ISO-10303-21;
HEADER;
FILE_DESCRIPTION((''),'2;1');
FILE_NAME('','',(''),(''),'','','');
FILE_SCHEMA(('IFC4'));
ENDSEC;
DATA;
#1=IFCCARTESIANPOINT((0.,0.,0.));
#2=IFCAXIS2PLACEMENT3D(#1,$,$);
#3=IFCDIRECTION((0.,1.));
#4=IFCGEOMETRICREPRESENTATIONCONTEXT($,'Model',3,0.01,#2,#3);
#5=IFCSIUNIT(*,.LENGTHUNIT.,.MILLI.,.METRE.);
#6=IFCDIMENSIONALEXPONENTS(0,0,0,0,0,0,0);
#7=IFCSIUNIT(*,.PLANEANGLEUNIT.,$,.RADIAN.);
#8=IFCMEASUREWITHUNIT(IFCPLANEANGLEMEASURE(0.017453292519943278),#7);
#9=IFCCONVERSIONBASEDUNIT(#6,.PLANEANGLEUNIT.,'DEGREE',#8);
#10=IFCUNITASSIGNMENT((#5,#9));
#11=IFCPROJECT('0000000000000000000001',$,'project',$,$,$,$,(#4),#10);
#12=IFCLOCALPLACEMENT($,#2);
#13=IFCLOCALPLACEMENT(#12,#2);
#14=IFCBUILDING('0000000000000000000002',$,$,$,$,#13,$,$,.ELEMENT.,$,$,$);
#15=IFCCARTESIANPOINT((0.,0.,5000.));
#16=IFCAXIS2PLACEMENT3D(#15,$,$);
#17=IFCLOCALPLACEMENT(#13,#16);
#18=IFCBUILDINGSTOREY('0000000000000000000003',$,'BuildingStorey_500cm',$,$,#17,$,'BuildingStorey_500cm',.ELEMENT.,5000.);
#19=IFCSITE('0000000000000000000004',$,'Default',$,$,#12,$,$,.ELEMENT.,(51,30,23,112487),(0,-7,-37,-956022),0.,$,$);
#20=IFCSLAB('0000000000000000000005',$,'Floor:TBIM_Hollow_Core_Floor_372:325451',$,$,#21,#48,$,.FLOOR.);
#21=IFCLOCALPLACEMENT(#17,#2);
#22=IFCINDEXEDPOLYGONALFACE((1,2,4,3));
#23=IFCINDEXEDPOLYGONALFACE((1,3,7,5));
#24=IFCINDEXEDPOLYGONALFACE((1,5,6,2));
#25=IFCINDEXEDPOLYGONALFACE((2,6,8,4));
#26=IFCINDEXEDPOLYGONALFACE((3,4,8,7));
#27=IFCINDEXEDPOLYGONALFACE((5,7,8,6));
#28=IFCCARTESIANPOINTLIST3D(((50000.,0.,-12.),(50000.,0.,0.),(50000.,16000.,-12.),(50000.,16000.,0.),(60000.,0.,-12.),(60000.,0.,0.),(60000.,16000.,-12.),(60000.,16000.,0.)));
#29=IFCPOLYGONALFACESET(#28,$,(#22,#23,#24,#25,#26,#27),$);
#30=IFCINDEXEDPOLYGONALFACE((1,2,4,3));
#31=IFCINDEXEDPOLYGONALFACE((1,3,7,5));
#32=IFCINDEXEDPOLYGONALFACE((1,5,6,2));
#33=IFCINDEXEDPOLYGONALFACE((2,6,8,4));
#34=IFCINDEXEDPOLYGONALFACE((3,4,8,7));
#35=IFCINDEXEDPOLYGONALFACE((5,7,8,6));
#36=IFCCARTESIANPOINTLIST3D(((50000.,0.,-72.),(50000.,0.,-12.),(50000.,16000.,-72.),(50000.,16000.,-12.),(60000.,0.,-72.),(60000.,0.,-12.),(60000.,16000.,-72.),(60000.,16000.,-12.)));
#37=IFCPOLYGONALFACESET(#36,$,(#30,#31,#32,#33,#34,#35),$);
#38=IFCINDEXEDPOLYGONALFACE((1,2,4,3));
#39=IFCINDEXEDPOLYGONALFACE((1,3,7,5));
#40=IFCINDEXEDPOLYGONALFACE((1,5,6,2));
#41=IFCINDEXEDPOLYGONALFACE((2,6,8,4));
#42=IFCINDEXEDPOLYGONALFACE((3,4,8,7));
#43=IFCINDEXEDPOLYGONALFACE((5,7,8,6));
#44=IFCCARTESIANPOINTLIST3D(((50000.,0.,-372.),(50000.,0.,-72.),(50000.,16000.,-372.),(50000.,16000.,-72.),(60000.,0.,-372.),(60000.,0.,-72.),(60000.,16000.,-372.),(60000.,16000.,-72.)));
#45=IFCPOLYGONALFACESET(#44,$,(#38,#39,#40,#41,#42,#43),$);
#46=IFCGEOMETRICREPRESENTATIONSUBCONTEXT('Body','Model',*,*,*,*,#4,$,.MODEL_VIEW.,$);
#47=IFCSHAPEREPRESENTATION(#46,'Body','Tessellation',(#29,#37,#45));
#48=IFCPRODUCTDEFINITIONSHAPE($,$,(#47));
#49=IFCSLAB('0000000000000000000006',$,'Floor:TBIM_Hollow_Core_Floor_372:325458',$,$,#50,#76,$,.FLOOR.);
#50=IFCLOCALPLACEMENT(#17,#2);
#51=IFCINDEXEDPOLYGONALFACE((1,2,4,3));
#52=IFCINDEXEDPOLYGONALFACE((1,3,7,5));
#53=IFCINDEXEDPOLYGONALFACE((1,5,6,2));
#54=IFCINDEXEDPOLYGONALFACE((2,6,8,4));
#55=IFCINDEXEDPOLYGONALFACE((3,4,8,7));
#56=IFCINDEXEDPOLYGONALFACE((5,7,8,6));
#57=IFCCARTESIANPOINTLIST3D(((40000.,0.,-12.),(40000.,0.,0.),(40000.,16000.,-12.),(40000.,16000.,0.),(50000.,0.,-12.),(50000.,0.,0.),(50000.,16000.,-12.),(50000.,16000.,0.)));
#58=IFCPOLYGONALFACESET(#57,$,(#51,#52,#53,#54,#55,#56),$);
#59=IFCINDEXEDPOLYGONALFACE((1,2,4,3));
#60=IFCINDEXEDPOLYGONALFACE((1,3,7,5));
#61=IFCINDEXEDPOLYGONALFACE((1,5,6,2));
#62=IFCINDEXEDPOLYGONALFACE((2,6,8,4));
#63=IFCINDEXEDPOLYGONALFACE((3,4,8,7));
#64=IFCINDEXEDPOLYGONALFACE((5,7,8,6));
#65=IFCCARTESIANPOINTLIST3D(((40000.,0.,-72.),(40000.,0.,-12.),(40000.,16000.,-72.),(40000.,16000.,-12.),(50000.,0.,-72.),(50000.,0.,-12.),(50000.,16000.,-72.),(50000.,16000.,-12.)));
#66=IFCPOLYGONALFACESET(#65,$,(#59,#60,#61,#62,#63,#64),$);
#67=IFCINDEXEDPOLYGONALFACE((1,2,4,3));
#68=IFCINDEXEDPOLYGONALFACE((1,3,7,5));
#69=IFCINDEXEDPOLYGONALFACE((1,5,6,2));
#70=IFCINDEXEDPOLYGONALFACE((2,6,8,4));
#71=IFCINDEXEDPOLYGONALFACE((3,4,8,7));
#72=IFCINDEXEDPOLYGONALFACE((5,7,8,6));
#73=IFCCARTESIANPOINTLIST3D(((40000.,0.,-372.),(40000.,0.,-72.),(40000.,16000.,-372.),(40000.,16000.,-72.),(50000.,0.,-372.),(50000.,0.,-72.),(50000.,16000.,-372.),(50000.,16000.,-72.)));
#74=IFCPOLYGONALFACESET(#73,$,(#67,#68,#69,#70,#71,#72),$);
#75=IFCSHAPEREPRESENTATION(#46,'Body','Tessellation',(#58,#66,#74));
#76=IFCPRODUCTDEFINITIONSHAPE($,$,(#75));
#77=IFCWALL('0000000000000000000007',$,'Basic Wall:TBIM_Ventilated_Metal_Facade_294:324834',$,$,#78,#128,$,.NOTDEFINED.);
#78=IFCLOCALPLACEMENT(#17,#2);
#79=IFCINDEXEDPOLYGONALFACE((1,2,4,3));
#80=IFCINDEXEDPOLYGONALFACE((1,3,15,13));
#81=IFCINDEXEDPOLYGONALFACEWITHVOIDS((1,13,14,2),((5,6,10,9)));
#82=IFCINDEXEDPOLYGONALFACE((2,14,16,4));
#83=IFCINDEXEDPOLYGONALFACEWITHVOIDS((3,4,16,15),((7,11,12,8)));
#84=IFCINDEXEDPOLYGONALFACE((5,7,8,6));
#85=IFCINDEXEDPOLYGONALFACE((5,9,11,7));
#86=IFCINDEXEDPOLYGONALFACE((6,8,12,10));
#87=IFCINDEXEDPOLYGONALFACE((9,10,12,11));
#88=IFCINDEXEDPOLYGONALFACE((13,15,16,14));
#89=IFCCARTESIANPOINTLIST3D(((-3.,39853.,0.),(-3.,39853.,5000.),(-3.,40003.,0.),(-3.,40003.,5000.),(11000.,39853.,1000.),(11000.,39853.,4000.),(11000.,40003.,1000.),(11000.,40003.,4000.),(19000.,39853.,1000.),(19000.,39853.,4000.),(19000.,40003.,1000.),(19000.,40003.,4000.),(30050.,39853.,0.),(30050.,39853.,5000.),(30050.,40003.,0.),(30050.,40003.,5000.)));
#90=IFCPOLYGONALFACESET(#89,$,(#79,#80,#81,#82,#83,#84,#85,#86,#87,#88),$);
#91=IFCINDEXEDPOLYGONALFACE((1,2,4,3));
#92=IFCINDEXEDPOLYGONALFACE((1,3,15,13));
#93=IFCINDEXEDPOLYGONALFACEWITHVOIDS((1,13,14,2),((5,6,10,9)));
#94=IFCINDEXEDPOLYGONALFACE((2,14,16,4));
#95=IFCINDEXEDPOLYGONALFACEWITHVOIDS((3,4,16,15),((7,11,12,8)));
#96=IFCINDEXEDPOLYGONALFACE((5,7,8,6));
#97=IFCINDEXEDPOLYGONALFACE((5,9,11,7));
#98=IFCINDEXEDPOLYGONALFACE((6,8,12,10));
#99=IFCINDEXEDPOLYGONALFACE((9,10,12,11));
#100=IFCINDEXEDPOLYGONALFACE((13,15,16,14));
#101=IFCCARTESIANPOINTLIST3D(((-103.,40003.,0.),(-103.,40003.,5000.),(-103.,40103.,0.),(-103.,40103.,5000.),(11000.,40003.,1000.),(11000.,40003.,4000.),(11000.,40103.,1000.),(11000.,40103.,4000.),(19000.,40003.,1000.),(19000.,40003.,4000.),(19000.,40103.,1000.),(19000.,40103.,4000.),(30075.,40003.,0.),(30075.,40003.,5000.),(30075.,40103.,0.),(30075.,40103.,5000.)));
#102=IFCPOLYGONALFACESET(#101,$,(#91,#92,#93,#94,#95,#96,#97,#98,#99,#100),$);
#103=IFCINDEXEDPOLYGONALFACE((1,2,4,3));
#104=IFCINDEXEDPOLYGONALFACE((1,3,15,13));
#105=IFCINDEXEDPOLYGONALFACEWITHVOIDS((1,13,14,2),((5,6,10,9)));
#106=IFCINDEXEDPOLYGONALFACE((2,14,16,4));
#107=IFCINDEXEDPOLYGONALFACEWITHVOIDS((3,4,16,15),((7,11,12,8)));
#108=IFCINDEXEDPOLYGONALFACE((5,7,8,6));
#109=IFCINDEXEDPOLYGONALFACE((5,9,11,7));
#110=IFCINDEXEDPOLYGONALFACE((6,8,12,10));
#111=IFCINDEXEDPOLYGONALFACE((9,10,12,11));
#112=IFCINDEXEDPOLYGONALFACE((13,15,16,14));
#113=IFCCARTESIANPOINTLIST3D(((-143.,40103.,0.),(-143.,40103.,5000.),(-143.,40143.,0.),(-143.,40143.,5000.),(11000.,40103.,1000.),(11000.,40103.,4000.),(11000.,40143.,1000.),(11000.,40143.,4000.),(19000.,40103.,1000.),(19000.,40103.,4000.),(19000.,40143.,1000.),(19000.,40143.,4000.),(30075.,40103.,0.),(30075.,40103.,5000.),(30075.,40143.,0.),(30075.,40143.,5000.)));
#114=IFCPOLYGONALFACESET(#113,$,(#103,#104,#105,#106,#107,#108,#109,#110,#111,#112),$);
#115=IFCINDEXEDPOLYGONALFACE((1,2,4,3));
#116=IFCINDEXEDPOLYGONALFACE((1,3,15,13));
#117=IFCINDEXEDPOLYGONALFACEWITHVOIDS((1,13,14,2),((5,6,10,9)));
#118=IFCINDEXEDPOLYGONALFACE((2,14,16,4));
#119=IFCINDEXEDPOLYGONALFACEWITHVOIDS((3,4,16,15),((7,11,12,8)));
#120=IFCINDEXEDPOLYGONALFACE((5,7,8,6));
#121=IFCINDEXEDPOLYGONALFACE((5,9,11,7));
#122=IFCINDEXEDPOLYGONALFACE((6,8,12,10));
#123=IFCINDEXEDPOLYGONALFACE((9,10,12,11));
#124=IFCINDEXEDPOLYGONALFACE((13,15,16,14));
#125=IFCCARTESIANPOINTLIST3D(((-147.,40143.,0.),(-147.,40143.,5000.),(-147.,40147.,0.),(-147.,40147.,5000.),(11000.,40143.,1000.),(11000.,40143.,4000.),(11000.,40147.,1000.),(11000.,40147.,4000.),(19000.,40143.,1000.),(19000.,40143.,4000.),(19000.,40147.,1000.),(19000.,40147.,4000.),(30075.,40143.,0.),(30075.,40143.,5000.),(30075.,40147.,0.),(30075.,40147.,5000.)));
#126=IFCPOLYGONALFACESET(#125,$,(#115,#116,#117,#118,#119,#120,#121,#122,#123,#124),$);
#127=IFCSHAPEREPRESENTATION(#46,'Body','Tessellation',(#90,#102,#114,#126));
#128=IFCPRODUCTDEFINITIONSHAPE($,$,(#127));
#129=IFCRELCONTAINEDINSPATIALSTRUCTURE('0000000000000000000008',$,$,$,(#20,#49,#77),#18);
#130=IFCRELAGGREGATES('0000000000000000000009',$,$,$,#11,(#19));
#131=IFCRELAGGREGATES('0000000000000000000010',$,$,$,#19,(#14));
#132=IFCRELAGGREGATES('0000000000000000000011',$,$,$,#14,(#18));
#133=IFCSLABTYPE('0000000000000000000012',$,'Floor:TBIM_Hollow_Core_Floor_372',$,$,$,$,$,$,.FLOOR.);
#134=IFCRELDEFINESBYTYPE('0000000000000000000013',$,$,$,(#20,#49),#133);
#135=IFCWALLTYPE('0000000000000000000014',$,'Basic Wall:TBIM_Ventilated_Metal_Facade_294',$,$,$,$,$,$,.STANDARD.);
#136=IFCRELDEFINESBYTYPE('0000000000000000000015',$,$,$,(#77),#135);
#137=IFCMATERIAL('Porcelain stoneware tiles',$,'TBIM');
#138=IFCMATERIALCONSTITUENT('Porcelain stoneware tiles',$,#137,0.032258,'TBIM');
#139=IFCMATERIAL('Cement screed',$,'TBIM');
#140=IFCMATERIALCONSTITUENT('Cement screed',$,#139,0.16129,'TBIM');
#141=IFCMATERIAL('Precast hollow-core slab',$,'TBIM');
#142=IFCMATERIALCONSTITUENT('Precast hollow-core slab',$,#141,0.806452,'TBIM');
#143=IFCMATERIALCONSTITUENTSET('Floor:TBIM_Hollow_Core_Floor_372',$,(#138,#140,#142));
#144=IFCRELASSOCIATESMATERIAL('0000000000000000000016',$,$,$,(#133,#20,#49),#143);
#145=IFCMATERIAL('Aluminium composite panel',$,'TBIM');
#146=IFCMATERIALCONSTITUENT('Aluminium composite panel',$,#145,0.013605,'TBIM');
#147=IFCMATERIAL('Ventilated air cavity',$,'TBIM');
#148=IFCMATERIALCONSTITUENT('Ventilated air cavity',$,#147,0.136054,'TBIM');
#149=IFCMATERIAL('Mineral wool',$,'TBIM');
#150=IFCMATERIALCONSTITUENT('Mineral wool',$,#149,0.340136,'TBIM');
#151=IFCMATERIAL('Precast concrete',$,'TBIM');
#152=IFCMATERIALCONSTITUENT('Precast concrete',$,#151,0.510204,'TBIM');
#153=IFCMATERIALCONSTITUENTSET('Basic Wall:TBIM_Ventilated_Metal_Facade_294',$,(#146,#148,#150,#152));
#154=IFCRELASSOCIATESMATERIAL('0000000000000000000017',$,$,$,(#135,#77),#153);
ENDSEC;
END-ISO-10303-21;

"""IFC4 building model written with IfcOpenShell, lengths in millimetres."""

from ifc_helpers import new_model, entity, si_unit, converted_unit, direction, frame, origin, place, context, subcontext, project, spatial, indexed_curve, outline, extrude, material, constituent, constituent_set, type_object, element, save


model = new_model("IFC4")

# Units and contexts
model_context = context("Model", 3, precision=0.01, world=origin(), true_north=direction((0.0, 1.0)))
body_context = subcontext(model_context, "Body", "Model", "MODEL_VIEW")
ifc_project = project(units=[si_unit("LENGTHUNIT", "METRE", prefix="MILLI"), converted_unit("PLANEANGLEUNIT", "DEGREE", entity("IfcPlaneAngleMeasure", 0.017453292519943278), si_unit("PLANEANGLEUNIT", "RADIAN"), dimensions=[0, 0, 0, 0, 0, 0, 0])], contexts=[model_context])

# Site, building, storey
site_placement = place(None, origin())
site = spatial("IfcSite", under=ifc_project, at=site_placement, Name="Default", CompositionType="ELEMENT", RefLatitude=(51, 30, 23, 112487), RefLongitude=(0, -7, -37, -956022), RefElevation=0.0)
building_placement = place(site_placement, origin())
building = spatial("IfcBuilding", under=site, at=building_placement, CompositionType="ELEMENT")
storey_placement = place(building_placement, frame((0.0, 0.0, 5000.0)))
storey = spatial("IfcBuildingStorey", under=building, at=storey_placement, Name="BuildingStorey_500cm", LongName="BuildingStorey_500cm", CompositionType="ELEMENT", Elevation=5000.0)

# Slabs
ifc_material_1 = material(Name="Porcelain stoneware tiles", Category="TBIM")
ifc_constituent_1 = constituent(ifc_material_1, Name="Porcelain stoneware tiles", Category="TBIM", fraction=0.032258)
ifc_material_2 = material(Name="Cement screed", Category="TBIM")
ifc_constituent_2 = constituent(ifc_material_2, Name="Cement screed", Category="TBIM", fraction=0.16129)
ifc_material_3 = material(Name="Precast hollow-core slab", Category="TBIM")
ifc_constituent_3 = constituent(ifc_material_3, Name="Precast hollow-core slab", Category="TBIM", fraction=0.806452)
ifc_constituent_set_1 = constituent_set(constituents=[ifc_constituent_1, ifc_constituent_2, ifc_constituent_3], Name="Floor:TBIM_Hollow_Core_Floor_372")
slab_type = type_object("IfcSlabType", Name="Floor:TBIM_Hollow_Core_Floor_372", PredefinedType="FLOOR", material=ifc_constituent_set_1)
slab_1_placement = place(storey_placement, origin())
element("IfcSlab", 1, at=slab_1_placement, inside=storey, type_object=slab_type, material=ifc_constituent_set_1, Name="Floor:TBIM_Hollow_Core_Floor_372:325451", PredefinedType="FLOOR", context=body_context, shape_type="SweptSolid", body=[
    extrude(outline(indexed_curve([(-5000.0, -8000.0), (5000.0, -8000.0), (5000.0, 8000.0), (-5000.0, 8000.0), (-5000.0, -8000.0)], self_intersect=False)), frame((55000.0, 8000.0, -12.0), z_axis=(0.0, 0.0, 1.0), x_axis=(-1.0, 0.0, 0.0)), (0.0, 0.0, 1.0), 12.0),
    extrude(outline(indexed_curve([(-5000.0, -8000.0), (5000.0, -8000.0), (5000.0, 8000.0), (-5000.0, 8000.0), (-5000.0, -8000.0)], self_intersect=False)), frame((55000.0, 8000.0, -72.0), z_axis=(0.0, 0.0, 1.0), x_axis=(-1.0, 0.0, 0.0)), (0.0, 0.0, 1.0), 60.0),
    extrude(outline(indexed_curve([(-5000.0, -8000.0), (5000.0, -8000.0), (5000.0, 8000.0), (-5000.0, 8000.0), (-5000.0, -8000.0)], self_intersect=False)), frame((55000.0, 8000.0, -372.0), z_axis=(0.0, 0.0, 1.0), x_axis=(-1.0, 0.0, 0.0)), (0.0, 0.0, 1.0), 300.0),
])
slab_2_placement = place(storey_placement, origin())
element("IfcSlab", 2, at=slab_2_placement, inside=storey, type_object=slab_type, material=ifc_constituent_set_1, Name="Floor:TBIM_Hollow_Core_Floor_372:325458", PredefinedType="FLOOR", context=body_context, shape_type="SweptSolid", body=[
    extrude(outline(indexed_curve([(-5000.0, -8000.0), (5000.0, -8000.0), (5000.0, 8000.0), (-5000.0, 8000.0), (-5000.0, -8000.0)], self_intersect=False)), frame((45000.0, 8000.0, -12.0), z_axis=(0.0, 0.0, 1.0), x_axis=(-1.0, 0.0, 0.0)), (0.0, 0.0, 1.0), 12.0),
    extrude(outline(indexed_curve([(-5000.0, -8000.0), (5000.0, -8000.0), (5000.0, 8000.0), (-5000.0, 8000.0), (-5000.0, -8000.0)], self_intersect=False)), frame((45000.0, 8000.0, -72.0), z_axis=(0.0, 0.0, 1.0), x_axis=(-1.0, 0.0, 0.0)), (0.0, 0.0, 1.0), 60.0),
    extrude(outline(indexed_curve([(-5000.0, -8000.0), (5000.0, -8000.0), (5000.0, 8000.0), (-5000.0, 8000.0), (-5000.0, -8000.0)], self_intersect=False)), frame((45000.0, 8000.0, -372.0), z_axis=(0.0, 0.0, 1.0), x_axis=(-1.0, 0.0, 0.0)), (0.0, 0.0, 1.0), 300.0),
])

# Shared definitions
ifc_material_4 = material(Name="Aluminium composite panel", Category="TBIM")
ifc_constituent_4 = constituent(ifc_material_4, Name="Aluminium composite panel", Category="TBIM", fraction=0.013605)
ifc_material_5 = material(Name="Ventilated air cavity", Category="TBIM")
ifc_constituent_5 = constituent(ifc_material_5, Name="Ventilated air cavity", Category="TBIM", fraction=0.136054)
ifc_material_6 = material(Name="Mineral wool", Category="TBIM")
ifc_constituent_6 = constituent(ifc_material_6, Name="Mineral wool", Category="TBIM", fraction=0.340136)
ifc_material_7 = material(Name="Precast concrete", Category="TBIM")
ifc_constituent_7 = constituent(ifc_material_7, Name="Precast concrete", Category="TBIM", fraction=0.510204)
ifc_constituent_set_2 = constituent_set(constituents=[ifc_constituent_4, ifc_constituent_5, ifc_constituent_6, ifc_constituent_7], Name="Basic Wall:TBIM_Ventilated_Metal_Facade_294")
wall_type_1 = type_object("IfcWallType", Name="Basic Wall:TBIM_Ventilated_Metal_Facade_294", PredefinedType="STANDARD", material=ifc_constituent_set_2)

# Wall, openings
wall_1_placement = place(storey_placement, frame((-147.0, 40000.0, 0.0)))
wall_1 = element("IfcWall", 3, at=wall_1_placement, inside=storey, type_object=wall_type_1, material=ifc_constituent_set_2, Name="Basic Wall:TBIM_Ventilated_Metal_Facade_294:324834", PredefinedType="NOTDEFINED", context=body_context, shape_type="SweptSolid", body=[
    extrude(outline(indexed_curve([(-14880.7, -50.0), (14897.3, -50.0), (15022.3, -50.0), (15022.3, 100.0), (-15030.7, 100.0), (-15030.7, -50.0), (-14880.7, -50.0)], self_intersect=False)), frame((15174.7, -97.0, 0.0)), (0.0, 0.0, 1.0), 5000.0),
    extrude(outline(indexed_curve([(-2500.0, -15089.0), (2500.0, -15089.0), (2500.0, 15089.0), (-2500.0, 15089.0), (-2500.0, -15089.0)], self_intersect=False), holes=[indexed_curve([(1500.0, 3986.0), (1500.0, -4014.0), (-1500.0, -4014.0), (-1500.0, 3986.0), (1500.0, 3986.0)], self_intersect=False)]), frame((15133.0, 3.0, 2500.0), z_axis=(0.0, 1.0, 0.0), x_axis=(0.0, 0.0, -1.0)), (0.0, 0.0, 1.0), 100.0),
    extrude(outline(indexed_curve([(-2500.0, -15109.0), (2500.0, -15109.0), (2500.0, 15109.0), (-2500.0, 15109.0), (-2500.0, -15109.0)], self_intersect=False), holes=[indexed_curve([(1500.0, 3966.0), (1500.0, -4034.0), (-1500.0, -4034.0), (-1500.0, 3966.0), (1500.0, 3966.0)], self_intersect=False)]), frame((15113.0, 103.0, 2500.0), z_axis=(0.0, 1.0, 0.0), x_axis=(0.0, 0.0, -1.0)), (0.0, 0.0, 1.0), 40.0),
    extrude(outline(indexed_curve([(-2.0, -15111.0), (2.0, -15111.0), (2.0, 15111.0), (-2.0, 15111.0), (-2.0, -15111.0)], self_intersect=False)), frame((15111.0, 145.0, 0.0), z_axis=(0.0, 0.0, 1.0), x_axis=(0.0, -1.0, 0.0)), (0.0, 0.0, 1.0), 5000.0),
])
opening_1_placement = place(storey_placement, frame((-147.0, 40000.0, 0.0)))
element("IfcOpeningElement", 4, at=opening_1_placement, cuts=wall_1, PredefinedType="OPENING", context=body_context, shape_type="SweptSolid", body=[
    extrude(outline(indexed_curve([(-1500.0, -4000.0), (1500.0, -4000.0), (1500.0, 4000.0), (-1500.0, 4000.0), (-1500.0, -4000.0)], self_intersect=False)), frame((15147.0, 143.0, 2500.0), z_axis=(0.0, 1.0, 0.0), x_axis=(0.0, 0.0, 1.0)), (0.0, 0.0, 1.0), 4.0),
])
opening_2_placement = place(storey_placement, frame((-147.0, 40000.0, 0.0)))
element("IfcOpeningElement", 5, at=opening_2_placement, cuts=wall_1, PredefinedType="OPENING", context=body_context, shape_type="SweptSolid", body=[
    extrude(outline(indexed_curve([(-1500.0, -4000.0), (1500.0, -4000.0), (1500.0, 4000.0), (-1500.0, 4000.0), (-1500.0, -4000.0)], self_intersect=False)), frame((15147.0, 3.0, 2500.0), z_axis=(0.0, -1.0, 0.0), x_axis=(0.0, 0.0, -1.0)), (0.0, 0.0, 1.0), 150.0),
])
opening_3_placement = place(wall_1_placement, frame((11147.0, -147.0, 1000.0)))
element("IfcOpeningElement", 6, at=opening_3_placement, cuts=wall_1, PredefinedType="OPENING", context=body_context, shape_type="SweptSolid", body=[
    extrude(outline(indexed_curve([(3000.0, 0.0), (3000.0, 8000.0), (0.0, 8000.0), (0.0, 0.0), (3000.0, 0.0)], self_intersect=False)), frame((0.0, 0.0, 0.0), z_axis=(0.0, 1.0, 0.0), x_axis=(0.0, 0.0, 1.0)), (0.0, 0.0, 1.0), 294.0),
])

save(model, "model.ifc")
